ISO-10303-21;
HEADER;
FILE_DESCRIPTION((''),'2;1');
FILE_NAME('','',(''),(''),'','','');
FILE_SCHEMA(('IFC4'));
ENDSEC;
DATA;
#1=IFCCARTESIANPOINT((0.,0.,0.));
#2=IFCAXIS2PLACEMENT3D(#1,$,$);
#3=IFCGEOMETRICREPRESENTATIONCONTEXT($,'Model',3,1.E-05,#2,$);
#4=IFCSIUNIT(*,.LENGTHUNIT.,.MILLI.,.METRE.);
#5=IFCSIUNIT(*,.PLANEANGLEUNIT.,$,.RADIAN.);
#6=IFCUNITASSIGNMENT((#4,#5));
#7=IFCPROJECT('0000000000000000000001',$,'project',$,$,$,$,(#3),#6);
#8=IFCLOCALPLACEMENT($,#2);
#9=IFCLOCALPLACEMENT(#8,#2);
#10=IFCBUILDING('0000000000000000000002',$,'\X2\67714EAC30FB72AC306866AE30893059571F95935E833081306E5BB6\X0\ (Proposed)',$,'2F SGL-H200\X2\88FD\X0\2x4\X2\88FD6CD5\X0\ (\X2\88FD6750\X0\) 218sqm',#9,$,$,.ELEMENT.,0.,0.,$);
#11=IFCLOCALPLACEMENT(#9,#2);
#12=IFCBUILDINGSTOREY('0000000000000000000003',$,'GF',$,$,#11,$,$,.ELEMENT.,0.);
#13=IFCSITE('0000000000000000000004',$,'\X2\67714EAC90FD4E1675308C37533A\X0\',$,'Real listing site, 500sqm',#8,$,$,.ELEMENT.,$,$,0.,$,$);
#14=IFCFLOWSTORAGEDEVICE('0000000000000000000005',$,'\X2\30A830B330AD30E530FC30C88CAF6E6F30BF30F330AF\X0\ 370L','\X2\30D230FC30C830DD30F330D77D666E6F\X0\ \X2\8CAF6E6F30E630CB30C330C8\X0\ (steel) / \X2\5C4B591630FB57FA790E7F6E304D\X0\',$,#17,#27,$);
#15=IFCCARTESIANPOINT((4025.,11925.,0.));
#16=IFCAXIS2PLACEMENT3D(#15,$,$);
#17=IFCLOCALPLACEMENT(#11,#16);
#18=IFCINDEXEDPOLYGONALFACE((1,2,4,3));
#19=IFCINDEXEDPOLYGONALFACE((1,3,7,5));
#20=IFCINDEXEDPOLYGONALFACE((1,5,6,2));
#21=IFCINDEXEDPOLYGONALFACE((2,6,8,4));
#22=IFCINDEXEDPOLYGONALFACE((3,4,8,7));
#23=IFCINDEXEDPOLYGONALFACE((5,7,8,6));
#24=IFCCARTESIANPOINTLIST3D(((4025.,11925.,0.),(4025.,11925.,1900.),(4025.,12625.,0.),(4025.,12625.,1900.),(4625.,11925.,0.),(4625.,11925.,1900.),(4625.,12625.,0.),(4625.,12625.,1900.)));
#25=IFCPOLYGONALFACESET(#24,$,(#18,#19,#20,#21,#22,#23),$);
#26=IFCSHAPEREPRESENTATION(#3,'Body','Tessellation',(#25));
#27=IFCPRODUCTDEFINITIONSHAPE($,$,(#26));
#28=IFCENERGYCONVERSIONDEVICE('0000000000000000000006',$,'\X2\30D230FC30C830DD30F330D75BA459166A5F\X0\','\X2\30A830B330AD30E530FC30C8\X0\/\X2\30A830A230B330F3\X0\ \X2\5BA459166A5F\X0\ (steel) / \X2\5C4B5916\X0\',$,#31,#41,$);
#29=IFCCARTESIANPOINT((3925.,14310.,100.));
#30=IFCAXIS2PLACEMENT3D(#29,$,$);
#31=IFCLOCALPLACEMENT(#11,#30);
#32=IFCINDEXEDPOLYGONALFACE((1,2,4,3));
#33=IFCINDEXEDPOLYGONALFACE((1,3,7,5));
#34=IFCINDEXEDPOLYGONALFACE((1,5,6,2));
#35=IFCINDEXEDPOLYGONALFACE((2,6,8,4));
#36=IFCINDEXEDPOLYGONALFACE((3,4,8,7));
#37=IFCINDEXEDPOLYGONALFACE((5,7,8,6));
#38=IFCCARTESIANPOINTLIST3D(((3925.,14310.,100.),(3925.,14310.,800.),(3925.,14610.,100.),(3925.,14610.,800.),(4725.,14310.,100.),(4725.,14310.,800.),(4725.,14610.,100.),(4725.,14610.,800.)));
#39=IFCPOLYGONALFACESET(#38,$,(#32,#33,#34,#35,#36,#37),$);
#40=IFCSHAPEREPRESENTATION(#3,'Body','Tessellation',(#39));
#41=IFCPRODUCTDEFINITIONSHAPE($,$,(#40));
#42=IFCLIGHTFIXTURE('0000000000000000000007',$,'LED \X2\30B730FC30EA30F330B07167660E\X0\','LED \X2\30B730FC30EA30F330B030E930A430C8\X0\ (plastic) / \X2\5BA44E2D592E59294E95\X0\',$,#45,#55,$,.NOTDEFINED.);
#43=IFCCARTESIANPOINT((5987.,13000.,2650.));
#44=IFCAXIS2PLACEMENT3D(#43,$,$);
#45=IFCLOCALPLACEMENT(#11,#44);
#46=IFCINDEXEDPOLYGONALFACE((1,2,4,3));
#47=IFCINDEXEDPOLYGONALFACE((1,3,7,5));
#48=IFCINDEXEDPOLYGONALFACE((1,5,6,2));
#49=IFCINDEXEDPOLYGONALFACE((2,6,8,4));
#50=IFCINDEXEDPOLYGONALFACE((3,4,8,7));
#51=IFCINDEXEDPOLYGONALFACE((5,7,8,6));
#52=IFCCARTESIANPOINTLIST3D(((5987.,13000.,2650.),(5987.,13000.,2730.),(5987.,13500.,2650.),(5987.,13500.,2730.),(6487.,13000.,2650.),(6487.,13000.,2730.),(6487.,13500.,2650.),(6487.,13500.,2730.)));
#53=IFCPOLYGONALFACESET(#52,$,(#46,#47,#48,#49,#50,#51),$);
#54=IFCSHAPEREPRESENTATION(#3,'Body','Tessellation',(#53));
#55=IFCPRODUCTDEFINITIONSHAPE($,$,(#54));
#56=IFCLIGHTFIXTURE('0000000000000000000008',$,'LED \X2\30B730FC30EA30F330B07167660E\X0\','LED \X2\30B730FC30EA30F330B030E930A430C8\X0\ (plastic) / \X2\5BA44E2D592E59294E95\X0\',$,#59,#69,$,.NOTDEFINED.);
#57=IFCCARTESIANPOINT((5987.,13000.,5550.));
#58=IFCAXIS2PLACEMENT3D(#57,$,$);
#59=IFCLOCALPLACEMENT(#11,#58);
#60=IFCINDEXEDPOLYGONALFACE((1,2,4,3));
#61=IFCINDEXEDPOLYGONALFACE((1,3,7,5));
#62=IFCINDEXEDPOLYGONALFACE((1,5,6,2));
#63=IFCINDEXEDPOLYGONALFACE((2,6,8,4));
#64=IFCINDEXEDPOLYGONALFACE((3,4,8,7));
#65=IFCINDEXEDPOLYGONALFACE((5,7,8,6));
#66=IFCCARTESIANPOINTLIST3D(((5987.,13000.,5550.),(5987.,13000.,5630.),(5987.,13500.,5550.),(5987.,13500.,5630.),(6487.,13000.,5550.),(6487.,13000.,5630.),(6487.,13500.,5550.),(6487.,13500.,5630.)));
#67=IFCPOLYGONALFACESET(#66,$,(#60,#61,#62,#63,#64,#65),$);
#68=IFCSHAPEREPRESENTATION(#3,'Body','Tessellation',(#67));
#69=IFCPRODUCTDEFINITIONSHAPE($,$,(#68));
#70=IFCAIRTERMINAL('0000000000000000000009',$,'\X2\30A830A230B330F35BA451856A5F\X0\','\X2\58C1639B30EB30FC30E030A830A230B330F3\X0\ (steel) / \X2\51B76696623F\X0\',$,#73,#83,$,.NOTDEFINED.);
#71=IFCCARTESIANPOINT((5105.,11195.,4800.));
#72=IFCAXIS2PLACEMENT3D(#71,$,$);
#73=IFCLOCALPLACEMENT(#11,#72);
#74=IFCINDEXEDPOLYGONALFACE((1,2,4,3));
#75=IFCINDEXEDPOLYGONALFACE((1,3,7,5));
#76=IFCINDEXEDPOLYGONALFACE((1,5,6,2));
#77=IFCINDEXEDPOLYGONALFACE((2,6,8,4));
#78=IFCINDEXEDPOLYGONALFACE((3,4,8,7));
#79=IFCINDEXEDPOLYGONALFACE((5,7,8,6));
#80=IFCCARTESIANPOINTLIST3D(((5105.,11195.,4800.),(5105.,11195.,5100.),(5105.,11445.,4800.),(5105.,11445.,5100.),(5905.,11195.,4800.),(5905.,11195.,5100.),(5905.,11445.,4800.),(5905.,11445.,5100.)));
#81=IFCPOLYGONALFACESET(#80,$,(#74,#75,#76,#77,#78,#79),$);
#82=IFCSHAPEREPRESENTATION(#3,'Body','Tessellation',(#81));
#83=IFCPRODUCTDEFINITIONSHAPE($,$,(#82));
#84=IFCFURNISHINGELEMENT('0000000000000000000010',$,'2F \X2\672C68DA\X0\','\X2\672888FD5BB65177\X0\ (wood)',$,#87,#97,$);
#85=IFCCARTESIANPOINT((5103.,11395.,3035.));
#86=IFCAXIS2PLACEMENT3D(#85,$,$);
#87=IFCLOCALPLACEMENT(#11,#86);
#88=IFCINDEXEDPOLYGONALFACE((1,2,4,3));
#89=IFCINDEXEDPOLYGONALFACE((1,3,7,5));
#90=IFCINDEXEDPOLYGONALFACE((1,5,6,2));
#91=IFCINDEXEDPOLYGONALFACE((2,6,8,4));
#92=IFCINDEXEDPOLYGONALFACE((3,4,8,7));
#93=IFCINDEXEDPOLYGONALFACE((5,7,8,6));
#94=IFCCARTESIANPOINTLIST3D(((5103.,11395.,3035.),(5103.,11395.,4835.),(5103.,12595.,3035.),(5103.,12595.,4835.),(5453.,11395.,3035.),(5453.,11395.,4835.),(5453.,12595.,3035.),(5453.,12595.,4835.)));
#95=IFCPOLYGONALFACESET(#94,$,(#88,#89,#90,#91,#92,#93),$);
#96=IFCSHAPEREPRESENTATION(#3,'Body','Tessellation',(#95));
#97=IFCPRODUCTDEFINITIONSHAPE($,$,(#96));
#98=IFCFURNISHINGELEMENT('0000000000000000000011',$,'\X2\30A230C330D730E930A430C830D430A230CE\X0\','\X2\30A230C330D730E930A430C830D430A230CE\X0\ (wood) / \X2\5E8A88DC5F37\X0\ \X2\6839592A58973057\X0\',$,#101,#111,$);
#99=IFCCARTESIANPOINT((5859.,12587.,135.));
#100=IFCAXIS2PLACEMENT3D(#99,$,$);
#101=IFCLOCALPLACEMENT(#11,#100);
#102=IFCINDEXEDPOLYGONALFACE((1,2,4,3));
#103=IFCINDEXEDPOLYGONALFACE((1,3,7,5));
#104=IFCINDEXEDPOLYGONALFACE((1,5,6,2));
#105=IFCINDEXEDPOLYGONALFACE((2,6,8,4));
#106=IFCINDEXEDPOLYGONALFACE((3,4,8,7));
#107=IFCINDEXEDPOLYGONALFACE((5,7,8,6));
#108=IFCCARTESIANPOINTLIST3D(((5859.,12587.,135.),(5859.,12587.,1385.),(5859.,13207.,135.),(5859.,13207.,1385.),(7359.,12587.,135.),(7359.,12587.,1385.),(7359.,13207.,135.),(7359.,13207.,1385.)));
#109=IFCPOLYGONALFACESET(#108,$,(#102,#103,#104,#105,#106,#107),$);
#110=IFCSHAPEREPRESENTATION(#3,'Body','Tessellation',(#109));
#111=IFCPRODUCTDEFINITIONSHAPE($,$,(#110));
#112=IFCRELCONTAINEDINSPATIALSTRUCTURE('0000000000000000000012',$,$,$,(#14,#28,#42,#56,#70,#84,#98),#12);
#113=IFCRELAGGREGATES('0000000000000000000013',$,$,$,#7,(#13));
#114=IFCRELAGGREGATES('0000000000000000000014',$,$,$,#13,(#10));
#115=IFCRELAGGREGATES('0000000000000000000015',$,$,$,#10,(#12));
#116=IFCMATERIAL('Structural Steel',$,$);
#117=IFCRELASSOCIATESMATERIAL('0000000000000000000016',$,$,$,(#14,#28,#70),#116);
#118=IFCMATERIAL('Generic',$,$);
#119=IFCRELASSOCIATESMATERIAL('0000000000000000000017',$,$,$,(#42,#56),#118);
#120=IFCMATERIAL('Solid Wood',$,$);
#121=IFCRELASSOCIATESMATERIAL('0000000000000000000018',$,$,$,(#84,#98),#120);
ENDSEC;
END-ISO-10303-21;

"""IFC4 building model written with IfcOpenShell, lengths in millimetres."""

from ifc_helpers import new_model, si_unit, frame, frame_2d, origin, place, context, project, spatial, rectangle, extrude, material, element, save


model = new_model("IFC4")

# Units and contexts
model_context = context("Model", 3, precision=1e-05, world=origin())
ifc_project = project(units=[si_unit("LENGTHUNIT", "METRE", prefix="MILLI"), si_unit("PLANEANGLEUNIT", "RADIAN")], contexts=[model_context])

# Site, building, storey
site_placement = place(None, origin())
site = spatial("IfcSite", under=ifc_project, at=site_placement, Name="東京都世田谷区", ObjectType="Real listing site, 500sqm", CompositionType="ELEMENT", RefElevation=0.0)
building_placement = place(site_placement, origin())
building = spatial("IfcBuilding", under=site, at=building_placement, Name="東京・犬と暮らす土間広めの家 (Proposed)", ObjectType="2F SGL-H200製2x4製法 (製材) 218sqm", CompositionType="ELEMENT", ElevationOfRefHeight=0.0, ElevationOfTerrain=0.0)
storey_placement = place(building_placement, origin())
storey = spatial("IfcBuildingStorey", under=building, at=storey_placement, Name="GF", CompositionType="ELEMENT", Elevation=0.0)

# Shared definitions
ifc_material_1 = material(Name="Solid Wood")

# Shared definitions
ifc_material_2 = material(Name="Structural Steel")

# Shared definitions
ifc_material_3 = material(Name="Generic")

# Flow storage device
flow_storage_device_placement = place(storey_placement, frame((4025.0, 11925.0, 0.0)))
element("IfcFlowStorageDevice", 1, at=flow_storage_device_placement, inside=storey, material=ifc_material_2, Name="エコキュート貯湯タンク 370L", Description="ヒートポンプ給湯 貯湯ユニット (steel) / 屋外・基礎置き", context=model_context, shape_type="SweptSolid", body=[
    extrude(rectangle(XDim=600.0, YDim=700.0, at=frame_2d((300.0, 350.0))), frame((4025.0, 11925.0, 0.0)), (0.0, 0.0, 1.0), 1900.0),
])

# Energy conversion device
energy_conversion_device_placement = place(storey_placement, frame((3925.0, 14310.0, 100.0)))
element("IfcEnergyConversionDevice", 2, at=energy_conversion_device_placement, inside=storey, material=ifc_material_2, Name="ヒートポンプ室外機", Description="エコキュート/エアコン 室外機 (steel) / 屋外", context=model_context, shape_type="SweptSolid", body=[
    extrude(rectangle(XDim=800.0, YDim=300.0, at=frame_2d((400.0, 150.0))), frame((3925.0, 14310.0, 100.0)), (0.0, 0.0, 1.0), 700.0),
])

# Light fixtures
light_fixture_1_placement = place(storey_placement, frame((5987.0, 13000.0, 2650.0)))
element("IfcLightFixture", 3, at=light_fixture_1_placement, inside=storey, material=ifc_material_3, Name="LED シーリング照明", Description="LED シーリングライト (plastic) / 室中央天井", PredefinedType="NOTDEFINED", context=model_context, shape_type="SweptSolid", body=[
    extrude(rectangle(XDim=500.0, YDim=500.0, at=frame_2d((250.0, 250.0))), frame((5987.0, 13000.0, 2650.0)), (0.0, 0.0, 1.0), 80.0),
])
light_fixture_2_placement = place(storey_placement, frame((5987.0, 13000.0, 5550.0)))
element("IfcLightFixture", 4, at=light_fixture_2_placement, inside=storey, material=ifc_material_3, Name="LED シーリング照明", Description="LED シーリングライト (plastic) / 室中央天井", PredefinedType="NOTDEFINED", context=model_context, shape_type="SweptSolid", body=[
    extrude(rectangle(XDim=500.0, YDim=500.0, at=frame_2d((250.0, 250.0))), frame((5987.0, 13000.0, 5550.0)), (0.0, 0.0, 1.0), 80.0),
])

# Air terminal
air_terminal_placement = place(storey_placement, frame((5105.0, 11195.0, 4800.0)))
element("IfcAirTerminal", 5, at=air_terminal_placement, inside=storey, material=ifc_material_2, Name="エアコン室内機", Description="壁掛ルームエアコン (steel) / 冷暖房", PredefinedType="NOTDEFINED", context=model_context, shape_type="SweptSolid", body=[
    extrude(rectangle(XDim=800.0, YDim=250.0, at=frame_2d((400.0, 125.0))), frame((5105.0, 11195.0, 4800.0)), (0.0, 0.0, 1.0), 300.0),
])

# Furnishing elements
furnishing_1_placement = place(storey_placement, frame((5103.0, 11395.0, 3035.0)))
element("IfcFurnishingElement", 6, at=furnishing_1_placement, inside=storey, material=ifc_material_1, Name="2F 本棚", Description="木製家具 (wood)", context=model_context, shape_type="SweptSolid", body=[
    extrude(rectangle(XDim=350.0, YDim=1200.0, at=frame_2d((175.0, 600.0))), frame((5103.0, 11395.0, 3035.0)), (0.0, 0.0, 1.0), 1800.0),
])
furnishing_2_placement = place(storey_placement, frame((5859.0, 12587.0, 135.0)))
element("IfcFurnishingElement", 7, at=furnishing_2_placement, inside=storey, material=ifc_material_1, Name="アップライトピアノ", Description="アップライトピアノ (wood) / 床補強 根太増し", context=model_context, shape_type="SweptSolid", body=[
    extrude(rectangle(XDim=1500.0, YDim=620.0, at=frame_2d((750.0, 310.0))), frame((5859.0, 12587.0, 135.0)), (0.0, 0.0, 1.0), 1250.0),
])

save(model, "model.ifc")
